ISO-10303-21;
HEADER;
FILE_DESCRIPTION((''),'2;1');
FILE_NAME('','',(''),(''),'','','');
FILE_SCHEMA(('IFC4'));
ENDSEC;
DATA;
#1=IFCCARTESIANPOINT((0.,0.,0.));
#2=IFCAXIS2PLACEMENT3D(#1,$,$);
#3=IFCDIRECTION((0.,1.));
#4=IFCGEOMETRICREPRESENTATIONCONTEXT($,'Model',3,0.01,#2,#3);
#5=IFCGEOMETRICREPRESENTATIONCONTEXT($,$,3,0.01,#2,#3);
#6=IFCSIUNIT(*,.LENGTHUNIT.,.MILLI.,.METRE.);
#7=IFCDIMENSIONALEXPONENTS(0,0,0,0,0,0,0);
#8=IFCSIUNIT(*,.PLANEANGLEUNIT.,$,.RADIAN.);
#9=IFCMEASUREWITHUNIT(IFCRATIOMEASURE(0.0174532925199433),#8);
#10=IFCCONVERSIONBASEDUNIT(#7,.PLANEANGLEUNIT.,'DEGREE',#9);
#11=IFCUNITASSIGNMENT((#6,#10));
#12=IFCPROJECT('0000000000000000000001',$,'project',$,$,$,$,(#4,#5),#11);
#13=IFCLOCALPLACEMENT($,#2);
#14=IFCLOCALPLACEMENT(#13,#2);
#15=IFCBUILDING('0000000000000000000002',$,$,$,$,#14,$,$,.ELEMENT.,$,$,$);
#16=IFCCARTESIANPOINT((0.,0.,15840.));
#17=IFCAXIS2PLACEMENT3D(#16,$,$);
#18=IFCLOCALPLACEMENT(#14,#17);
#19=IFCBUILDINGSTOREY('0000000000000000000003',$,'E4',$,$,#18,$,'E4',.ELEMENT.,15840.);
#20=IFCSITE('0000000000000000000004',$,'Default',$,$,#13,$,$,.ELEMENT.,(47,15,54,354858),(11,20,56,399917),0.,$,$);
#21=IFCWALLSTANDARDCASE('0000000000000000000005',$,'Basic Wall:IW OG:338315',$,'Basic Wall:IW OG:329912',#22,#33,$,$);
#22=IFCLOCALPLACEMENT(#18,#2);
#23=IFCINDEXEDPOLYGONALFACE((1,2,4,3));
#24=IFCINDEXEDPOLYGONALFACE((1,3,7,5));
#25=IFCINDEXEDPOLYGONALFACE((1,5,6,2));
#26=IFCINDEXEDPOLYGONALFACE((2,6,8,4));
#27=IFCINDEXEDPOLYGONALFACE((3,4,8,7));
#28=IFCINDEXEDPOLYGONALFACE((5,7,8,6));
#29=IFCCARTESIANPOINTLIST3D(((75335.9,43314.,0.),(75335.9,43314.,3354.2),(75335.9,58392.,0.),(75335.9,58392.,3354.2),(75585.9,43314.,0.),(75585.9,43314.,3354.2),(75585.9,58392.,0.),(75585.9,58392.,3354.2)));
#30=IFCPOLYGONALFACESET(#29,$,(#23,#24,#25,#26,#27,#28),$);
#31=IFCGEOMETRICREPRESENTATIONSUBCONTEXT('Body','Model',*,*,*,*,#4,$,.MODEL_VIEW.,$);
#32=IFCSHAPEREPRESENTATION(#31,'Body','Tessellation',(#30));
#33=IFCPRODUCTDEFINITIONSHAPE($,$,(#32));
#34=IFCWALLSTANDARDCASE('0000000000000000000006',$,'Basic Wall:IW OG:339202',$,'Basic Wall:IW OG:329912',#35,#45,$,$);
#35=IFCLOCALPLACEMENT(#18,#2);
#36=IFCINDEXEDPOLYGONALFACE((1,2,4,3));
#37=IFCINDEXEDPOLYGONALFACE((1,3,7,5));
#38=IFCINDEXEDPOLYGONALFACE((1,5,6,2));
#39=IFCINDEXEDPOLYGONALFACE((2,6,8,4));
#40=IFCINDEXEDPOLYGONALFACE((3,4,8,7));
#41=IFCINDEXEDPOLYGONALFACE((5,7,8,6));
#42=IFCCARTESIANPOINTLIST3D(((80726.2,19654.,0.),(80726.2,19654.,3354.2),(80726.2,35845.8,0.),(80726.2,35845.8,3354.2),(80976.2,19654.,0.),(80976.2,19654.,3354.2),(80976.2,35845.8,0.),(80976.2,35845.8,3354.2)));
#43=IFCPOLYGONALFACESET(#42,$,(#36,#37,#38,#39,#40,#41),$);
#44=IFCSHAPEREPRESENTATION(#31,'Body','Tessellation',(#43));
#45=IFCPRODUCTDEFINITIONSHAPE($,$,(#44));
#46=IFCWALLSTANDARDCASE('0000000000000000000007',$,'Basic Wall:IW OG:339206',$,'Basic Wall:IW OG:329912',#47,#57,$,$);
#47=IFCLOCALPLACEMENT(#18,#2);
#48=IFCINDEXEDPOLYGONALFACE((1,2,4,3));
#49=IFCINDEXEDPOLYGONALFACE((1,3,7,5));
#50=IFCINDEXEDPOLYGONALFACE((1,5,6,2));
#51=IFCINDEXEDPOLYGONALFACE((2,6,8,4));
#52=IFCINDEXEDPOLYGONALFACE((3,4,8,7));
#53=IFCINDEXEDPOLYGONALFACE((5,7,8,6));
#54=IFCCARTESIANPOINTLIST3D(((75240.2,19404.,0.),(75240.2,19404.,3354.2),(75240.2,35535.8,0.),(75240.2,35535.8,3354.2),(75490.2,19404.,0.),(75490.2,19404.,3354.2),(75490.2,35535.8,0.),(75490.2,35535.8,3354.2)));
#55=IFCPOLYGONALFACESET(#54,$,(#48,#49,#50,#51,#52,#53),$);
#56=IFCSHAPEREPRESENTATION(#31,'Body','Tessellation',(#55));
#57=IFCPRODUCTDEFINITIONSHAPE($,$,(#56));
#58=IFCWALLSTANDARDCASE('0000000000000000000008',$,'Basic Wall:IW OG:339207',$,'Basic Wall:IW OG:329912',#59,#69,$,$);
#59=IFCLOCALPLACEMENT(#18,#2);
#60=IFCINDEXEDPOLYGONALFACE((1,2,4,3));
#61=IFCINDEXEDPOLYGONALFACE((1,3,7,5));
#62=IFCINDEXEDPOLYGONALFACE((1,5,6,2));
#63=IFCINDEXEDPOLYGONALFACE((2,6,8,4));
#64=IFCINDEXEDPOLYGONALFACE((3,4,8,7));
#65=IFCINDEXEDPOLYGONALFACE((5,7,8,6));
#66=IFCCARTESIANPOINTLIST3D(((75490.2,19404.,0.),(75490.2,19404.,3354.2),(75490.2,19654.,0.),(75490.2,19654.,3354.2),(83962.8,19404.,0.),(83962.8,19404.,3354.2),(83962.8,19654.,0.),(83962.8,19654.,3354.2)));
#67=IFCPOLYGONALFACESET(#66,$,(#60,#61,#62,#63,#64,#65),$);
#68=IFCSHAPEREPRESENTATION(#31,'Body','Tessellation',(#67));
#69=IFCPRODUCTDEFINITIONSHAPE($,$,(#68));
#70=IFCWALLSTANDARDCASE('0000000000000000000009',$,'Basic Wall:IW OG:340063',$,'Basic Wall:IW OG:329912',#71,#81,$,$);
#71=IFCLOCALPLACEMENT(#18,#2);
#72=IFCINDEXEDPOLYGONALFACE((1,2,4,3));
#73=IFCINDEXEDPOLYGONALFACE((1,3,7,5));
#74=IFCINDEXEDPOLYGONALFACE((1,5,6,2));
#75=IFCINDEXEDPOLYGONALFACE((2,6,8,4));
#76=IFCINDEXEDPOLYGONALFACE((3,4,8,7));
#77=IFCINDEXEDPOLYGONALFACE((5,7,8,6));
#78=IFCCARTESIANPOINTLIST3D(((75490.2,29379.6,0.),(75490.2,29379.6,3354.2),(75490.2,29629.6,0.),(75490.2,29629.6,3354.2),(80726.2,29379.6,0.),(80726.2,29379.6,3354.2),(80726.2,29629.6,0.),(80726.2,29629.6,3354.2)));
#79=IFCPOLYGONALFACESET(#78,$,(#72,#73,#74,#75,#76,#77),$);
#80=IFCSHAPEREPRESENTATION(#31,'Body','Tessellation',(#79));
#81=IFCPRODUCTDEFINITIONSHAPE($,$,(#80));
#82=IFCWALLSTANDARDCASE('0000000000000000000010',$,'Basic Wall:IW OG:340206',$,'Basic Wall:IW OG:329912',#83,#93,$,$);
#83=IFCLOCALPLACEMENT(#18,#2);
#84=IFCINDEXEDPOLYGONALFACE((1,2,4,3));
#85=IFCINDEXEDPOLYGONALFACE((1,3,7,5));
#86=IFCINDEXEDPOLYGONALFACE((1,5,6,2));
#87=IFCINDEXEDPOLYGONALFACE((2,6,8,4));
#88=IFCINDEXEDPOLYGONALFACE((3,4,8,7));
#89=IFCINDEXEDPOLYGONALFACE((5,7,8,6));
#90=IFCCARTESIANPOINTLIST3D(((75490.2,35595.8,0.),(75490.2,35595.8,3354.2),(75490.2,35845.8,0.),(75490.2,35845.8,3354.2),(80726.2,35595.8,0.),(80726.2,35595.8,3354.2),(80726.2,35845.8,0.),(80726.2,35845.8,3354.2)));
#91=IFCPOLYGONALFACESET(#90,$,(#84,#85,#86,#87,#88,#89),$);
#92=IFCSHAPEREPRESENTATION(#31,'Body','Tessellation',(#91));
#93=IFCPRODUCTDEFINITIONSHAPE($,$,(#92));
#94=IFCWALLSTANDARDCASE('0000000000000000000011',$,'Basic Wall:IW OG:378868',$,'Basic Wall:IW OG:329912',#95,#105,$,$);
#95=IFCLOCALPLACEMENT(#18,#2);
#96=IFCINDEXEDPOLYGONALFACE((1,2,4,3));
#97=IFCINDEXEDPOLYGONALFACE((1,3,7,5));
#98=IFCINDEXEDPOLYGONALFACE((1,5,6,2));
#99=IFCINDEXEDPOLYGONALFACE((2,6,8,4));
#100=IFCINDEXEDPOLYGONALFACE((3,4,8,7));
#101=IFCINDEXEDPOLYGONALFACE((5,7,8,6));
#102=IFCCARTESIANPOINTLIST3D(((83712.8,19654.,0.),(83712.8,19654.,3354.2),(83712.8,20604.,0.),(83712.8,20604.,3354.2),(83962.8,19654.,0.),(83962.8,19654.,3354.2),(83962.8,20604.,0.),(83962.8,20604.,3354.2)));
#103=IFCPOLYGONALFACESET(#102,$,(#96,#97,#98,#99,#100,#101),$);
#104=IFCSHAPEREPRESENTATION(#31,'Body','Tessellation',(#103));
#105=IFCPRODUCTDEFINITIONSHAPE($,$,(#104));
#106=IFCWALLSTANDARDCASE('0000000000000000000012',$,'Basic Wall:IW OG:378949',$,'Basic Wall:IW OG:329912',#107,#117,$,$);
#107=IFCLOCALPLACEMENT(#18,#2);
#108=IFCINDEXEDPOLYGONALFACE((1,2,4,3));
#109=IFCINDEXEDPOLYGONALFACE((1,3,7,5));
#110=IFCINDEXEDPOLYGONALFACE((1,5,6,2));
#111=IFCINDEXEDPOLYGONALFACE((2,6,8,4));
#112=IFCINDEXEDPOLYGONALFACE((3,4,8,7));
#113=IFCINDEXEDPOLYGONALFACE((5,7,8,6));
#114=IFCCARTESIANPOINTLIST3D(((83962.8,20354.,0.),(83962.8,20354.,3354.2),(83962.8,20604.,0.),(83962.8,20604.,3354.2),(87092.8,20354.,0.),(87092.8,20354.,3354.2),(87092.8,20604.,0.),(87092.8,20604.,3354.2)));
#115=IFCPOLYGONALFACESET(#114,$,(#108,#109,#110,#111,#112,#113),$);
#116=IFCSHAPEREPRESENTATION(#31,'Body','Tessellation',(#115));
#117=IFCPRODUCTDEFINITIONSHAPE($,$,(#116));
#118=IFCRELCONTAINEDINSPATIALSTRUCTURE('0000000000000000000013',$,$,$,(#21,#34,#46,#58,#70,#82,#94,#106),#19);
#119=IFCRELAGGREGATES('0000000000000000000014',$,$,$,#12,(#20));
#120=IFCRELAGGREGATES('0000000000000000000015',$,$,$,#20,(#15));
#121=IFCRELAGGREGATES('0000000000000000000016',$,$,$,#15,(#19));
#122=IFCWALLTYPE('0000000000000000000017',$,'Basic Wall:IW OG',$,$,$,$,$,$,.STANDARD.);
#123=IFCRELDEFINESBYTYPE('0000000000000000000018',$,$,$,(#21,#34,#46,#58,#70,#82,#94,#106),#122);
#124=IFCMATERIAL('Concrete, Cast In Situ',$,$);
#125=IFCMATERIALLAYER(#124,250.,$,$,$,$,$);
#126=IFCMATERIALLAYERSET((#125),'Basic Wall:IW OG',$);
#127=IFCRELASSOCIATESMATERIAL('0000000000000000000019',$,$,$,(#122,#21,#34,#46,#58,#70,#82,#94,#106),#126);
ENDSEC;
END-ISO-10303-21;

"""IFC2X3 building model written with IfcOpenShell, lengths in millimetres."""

from ifc_helpers import new_model, entity, si_unit, converted_unit, direction, frame, frame_2d, origin, place, context, subcontext, project, spatial, polyline, rectangle, extrude, clip, bounded_halfspace, material, layer, layer_set, layer_usage, type_object, element, save


model = new_model("IFC2X3")

# Units and contexts
model_context = context("Model", 3, precision=0.01, world=origin(), true_north=direction((0.0, 1.0)))
context_of_model = context(None, 3, precision=0.01, world=origin(), true_north=direction((0.0, 1.0)))
body_context = subcontext(model_context, "Body", "Model", "MODEL_VIEW")
ifc_project = project(units=[si_unit("LENGTHUNIT", "METRE", prefix="MILLI"), converted_unit("PLANEANGLEUNIT", "DEGREE", entity("IfcRatioMeasure", 0.0174532925199433), si_unit("PLANEANGLEUNIT", "RADIAN"), dimensions=[0, 0, 0, 0, 0, 0, 0])], contexts=[model_context, context_of_model])

# Site, building, storey
site_placement = place(None, origin())
site = spatial("IfcSite", under=ifc_project, at=site_placement, Name="Default", CompositionType="ELEMENT", RefLatitude=(47, 15, 54, 354858), RefLongitude=(11, 20, 56, 399917), RefElevation=0.0)
building_placement = place(site_placement, origin())
building = spatial("IfcBuilding", under=site, at=building_placement, CompositionType="ELEMENT")
storey_placement = place(building_placement, frame((0.0, 0.0, 15840.0)))
storey = spatial("IfcBuildingStorey", under=building, at=storey_placement, Name="E4", LongName="E4", CompositionType="ELEMENT", Elevation=15840.0)

# Walls
ifc_material_1 = material(Name="Concrete, Cast In Situ")
ifc_layer_1 = layer(ifc_material_1, 250.0)
ifc_layer_set_1 = layer_set([ifc_layer_1], Name="Basic Wall:IW OG")
ifc_layer_usage_1 = layer_usage(ifc_layer_set_1, "AXIS2", "POSITIVE", -125.0)
wall_type_1 = type_object("IfcWallType", Name="Basic Wall:IW OG", PredefinedType="STANDARD", material=ifc_layer_set_1)
wall_1_placement = place(storey_placement, frame((75460.9, 43314.0, 0.0), z_axis=(0.0, 0.0, 1.0), x_axis=(0.0, 1.0, 0.0)))
element("IfcWallStandardCase", 1, at=wall_1_placement, inside=storey, type_object=wall_type_1, material=ifc_layer_usage_1, Name="Basic Wall:IW OG:338315", ObjectType="Basic Wall:IW OG:329912", context=body_context, shape_type="Clipping", body=[
    clip(extrude(rectangle(XDim=15078.0, YDim=250.0, at=frame_2d((7539.0, 0.0), x_axis=(-1.0, 0.0))), origin(), (0.0, 0.0, 1.0), 3354.2), bounded_halfspace(frame((0.0, -125.0, 3354.2), z_axis=(0.0, 0.0, -1.0), x_axis=(0.0, -1.0, 0.0)), True, frame((0.0, -125.0, 3354.2)), polyline([(0.0, 0.0), (15078.0, 0.0), (15078.0, 250.0), (0.0, 250.0), (0.0, 0.0)]))),
])
ifc_layer_usage_2 = layer_usage(ifc_layer_set_1, "AXIS2", "NEGATIVE", 125.0)
wall_2_placement = place(storey_placement, frame((80851.2, 35845.8, 0.0), z_axis=(0.0, 0.0, 1.0), x_axis=(0.0, -1.0, 0.0)))
element("IfcWallStandardCase", 2, at=wall_2_placement, inside=storey, type_object=wall_type_1, material=ifc_layer_usage_2, Name="Basic Wall:IW OG:339202", ObjectType="Basic Wall:IW OG:329912", context=body_context, shape_type="Clipping", body=[
    clip(extrude(rectangle(XDim=16191.8, YDim=250.0, at=frame_2d((8095.9, 0.0), x_axis=(-1.0, 0.0))), origin(), (0.0, 0.0, 1.0), 3354.2), bounded_halfspace(frame((0.0, -125.0, 3354.2), z_axis=(0.0, 0.0, -1.0), x_axis=(0.0, 1.0, 0.0)), True, frame((0.0, -125.0, 3354.2)), polyline([(0.0, 0.0), (250.0, 0.0), (6216.2, 0.0), (6466.2, 0.0), (16191.8, 0.0), (16191.8, 250.0), (0.0, 250.0), (0.0, 0.0)]))),
])
ifc_layer_usage_3 = layer_usage(ifc_layer_set_1, "AXIS2", "NEGATIVE", 125.0)
wall_3_placement = place(storey_placement, frame((75365.2, 35535.8, 0.0), z_axis=(0.0, 0.0, 1.0), x_axis=(0.0, -1.0, 0.0)))
element("IfcWallStandardCase", 3, at=wall_3_placement, inside=storey, type_object=wall_type_1, material=ifc_layer_usage_3, Name="Basic Wall:IW OG:339206", ObjectType="Basic Wall:IW OG:329912", context=body_context, shape_type="Clipping", body=[
    clip(extrude(rectangle(XDim=16131.8, YDim=250.0, at=frame_2d((8065.9, 0.0), x_axis=(-1.0, 0.0))), origin(), (0.0, 0.0, 1.0), 3354.2), bounded_halfspace(frame((0.0, -125.0, 3354.2), z_axis=(0.0, 0.0, -1.0), x_axis=(0.0, 1.0, 0.0)), True, frame((0.0, -125.0, 3354.2)), polyline([(0.0, 0.0), (16131.8, 0.0), (16131.8, 250.0), (15881.8, 250.0), (6156.2, 250.0), (5906.2, 250.0), (0.0, 250.0), (0.0, 0.0)]))),
])
ifc_layer_usage_4 = layer_usage(ifc_layer_set_1, "AXIS2", "NEGATIVE", 125.0)
wall_4_placement = place(storey_placement, frame((75490.2, 19529.0, 0.0)))
element("IfcWallStandardCase", 4, at=wall_4_placement, inside=storey, type_object=wall_type_1, material=ifc_layer_usage_4, Name="Basic Wall:IW OG:339207", ObjectType="Basic Wall:IW OG:329912", context=body_context, shape_type="Clipping", body=[
    clip(extrude(rectangle(XDim=8472.6, YDim=250.0, at=frame_2d((4236.3, 0.0), x_axis=(-1.0, 0.0))), origin(), (0.0, 0.0, 1.0), 3354.2), bounded_halfspace(frame((0.0, -125.0, 3354.2), z_axis=(0.0, 0.0, -1.0), x_axis=(1.0, 0.0, 0.0)), True, frame((0.0, -125.0, 3354.2)), polyline([(0.0, 0.0), (8472.6, 0.0), (8472.6, 250.0), (8222.6, 250.0), (5486.0, 250.0), (5236.0, 250.0), (0.0, 250.0), (0.0, 0.0)]))),
])
ifc_layer_usage_5 = layer_usage(ifc_layer_set_1, "AXIS2", "NEGATIVE", 125.0)
wall_5_placement = place(storey_placement, frame((75490.2, 29504.6, 0.0)))
element("IfcWallStandardCase", 5, at=wall_5_placement, inside=storey, type_object=wall_type_1, material=ifc_layer_usage_5, Name="Basic Wall:IW OG:340063", ObjectType="Basic Wall:IW OG:329912", context=body_context, shape_type="Clipping", body=[
    clip(extrude(rectangle(XDim=5236.0, YDim=250.0, at=frame_2d((2618.0, 0.0), x_axis=(-1.0, 0.0))), origin(), (0.0, 0.0, 1.0), 3354.2), bounded_halfspace(frame((0.0, -125.0, 3354.2), z_axis=(0.0, 0.0, -1.0), x_axis=(1.0, 0.0, 0.0)), True, frame((0.0, -125.0, 3354.2)), polyline([(0.0, 0.0), (5236.0, 0.0), (5236.0, 250.0), (0.0, 250.0), (0.0, 0.0)]))),
])
ifc_layer_usage_6 = layer_usage(ifc_layer_set_1, "AXIS2", "NEGATIVE", 125.0)
wall_6_placement = place(storey_placement, frame((75490.2, 35720.8, 0.0)))
element("IfcWallStandardCase", 6, at=wall_6_placement, inside=storey, type_object=wall_type_1, material=ifc_layer_usage_6, Name="Basic Wall:IW OG:340206", ObjectType="Basic Wall:IW OG:329912", context=body_context, shape_type="Clipping", body=[
    clip(extrude(rectangle(XDim=5236.0, YDim=250.0, at=frame_2d((2618.0, 0.0), x_axis=(-1.0, 0.0))), origin(), (0.0, 0.0, 1.0), 3354.2), bounded_halfspace(frame((155.2, -125.0, 3354.2), z_axis=(0.0, 0.0, -1.0), x_axis=(1.0, 0.0, 0.0)), True, frame((155.2, -125.0, 3354.2)), polyline([(0.0, 0.0), (5080.8, 0.0), (5080.8, 250.0), (0.0, 250.0), (0.0, 0.0)]))),
])
ifc_layer_usage_7 = layer_usage(ifc_layer_set_1, "AXIS2", "NEGATIVE", 125.0)
wall_7_placement = place(storey_placement, frame((83837.8, 19654.0, 0.0), z_axis=(0.0, 0.0, 1.0), x_axis=(0.0, 1.0, 0.0)))
element("IfcWallStandardCase", 7, at=wall_7_placement, inside=storey, type_object=wall_type_1, material=ifc_layer_usage_7, Name="Basic Wall:IW OG:378868", ObjectType="Basic Wall:IW OG:329912", context=body_context, shape_type="Clipping", body=[
    clip(extrude(rectangle(XDim=950.0, YDim=250.0, at=frame_2d((475.0, 0.0), x_axis=(-1.0, 0.0))), origin(), (0.0, 0.0, 1.0), 3354.2), bounded_halfspace(frame((0.0, -125.0, 3354.2), z_axis=(0.0, 0.0, -1.0), x_axis=(0.0, -1.0, 0.0)), True, frame((0.0, -125.0, 3354.2)), polyline([(0.0, 0.0), (700.0, 0.0), (950.0, 0.0), (950.0, 250.0), (0.0, 250.0), (0.0, 0.0)]))),
])
ifc_layer_usage_8 = layer_usage(ifc_layer_set_1, "AXIS2", "NEGATIVE", 125.0)
wall_8_placement = place(storey_placement, frame((83962.8, 20479.0, 0.0)))
element("IfcWallStandardCase", 8, at=wall_8_placement, inside=storey, type_object=wall_type_1, material=ifc_layer_usage_8, Name="Basic Wall:IW OG:378949", ObjectType="Basic Wall:IW OG:329912", context=body_context, shape_type="Clipping", body=[
    clip(extrude(rectangle(XDim=3130.0, YDim=250.0, at=frame_2d((1565.0, 0.0), x_axis=(-1.0, 0.0))), origin(), (0.0, 0.0, 1.0), 3354.2), bounded_halfspace(frame((0.0, -125.0, 3354.2), z_axis=(0.0, 0.0, -1.0), x_axis=(1.0, 0.0, 0.0)), True, frame((0.0, -125.0, 3354.2)), polyline([(0.0, 0.0), (3130.0, 0.0), (3130.0, 250.0), (0.0, 250.0), (0.0, 0.0)]))),
])

save(model, "model.ifc")
